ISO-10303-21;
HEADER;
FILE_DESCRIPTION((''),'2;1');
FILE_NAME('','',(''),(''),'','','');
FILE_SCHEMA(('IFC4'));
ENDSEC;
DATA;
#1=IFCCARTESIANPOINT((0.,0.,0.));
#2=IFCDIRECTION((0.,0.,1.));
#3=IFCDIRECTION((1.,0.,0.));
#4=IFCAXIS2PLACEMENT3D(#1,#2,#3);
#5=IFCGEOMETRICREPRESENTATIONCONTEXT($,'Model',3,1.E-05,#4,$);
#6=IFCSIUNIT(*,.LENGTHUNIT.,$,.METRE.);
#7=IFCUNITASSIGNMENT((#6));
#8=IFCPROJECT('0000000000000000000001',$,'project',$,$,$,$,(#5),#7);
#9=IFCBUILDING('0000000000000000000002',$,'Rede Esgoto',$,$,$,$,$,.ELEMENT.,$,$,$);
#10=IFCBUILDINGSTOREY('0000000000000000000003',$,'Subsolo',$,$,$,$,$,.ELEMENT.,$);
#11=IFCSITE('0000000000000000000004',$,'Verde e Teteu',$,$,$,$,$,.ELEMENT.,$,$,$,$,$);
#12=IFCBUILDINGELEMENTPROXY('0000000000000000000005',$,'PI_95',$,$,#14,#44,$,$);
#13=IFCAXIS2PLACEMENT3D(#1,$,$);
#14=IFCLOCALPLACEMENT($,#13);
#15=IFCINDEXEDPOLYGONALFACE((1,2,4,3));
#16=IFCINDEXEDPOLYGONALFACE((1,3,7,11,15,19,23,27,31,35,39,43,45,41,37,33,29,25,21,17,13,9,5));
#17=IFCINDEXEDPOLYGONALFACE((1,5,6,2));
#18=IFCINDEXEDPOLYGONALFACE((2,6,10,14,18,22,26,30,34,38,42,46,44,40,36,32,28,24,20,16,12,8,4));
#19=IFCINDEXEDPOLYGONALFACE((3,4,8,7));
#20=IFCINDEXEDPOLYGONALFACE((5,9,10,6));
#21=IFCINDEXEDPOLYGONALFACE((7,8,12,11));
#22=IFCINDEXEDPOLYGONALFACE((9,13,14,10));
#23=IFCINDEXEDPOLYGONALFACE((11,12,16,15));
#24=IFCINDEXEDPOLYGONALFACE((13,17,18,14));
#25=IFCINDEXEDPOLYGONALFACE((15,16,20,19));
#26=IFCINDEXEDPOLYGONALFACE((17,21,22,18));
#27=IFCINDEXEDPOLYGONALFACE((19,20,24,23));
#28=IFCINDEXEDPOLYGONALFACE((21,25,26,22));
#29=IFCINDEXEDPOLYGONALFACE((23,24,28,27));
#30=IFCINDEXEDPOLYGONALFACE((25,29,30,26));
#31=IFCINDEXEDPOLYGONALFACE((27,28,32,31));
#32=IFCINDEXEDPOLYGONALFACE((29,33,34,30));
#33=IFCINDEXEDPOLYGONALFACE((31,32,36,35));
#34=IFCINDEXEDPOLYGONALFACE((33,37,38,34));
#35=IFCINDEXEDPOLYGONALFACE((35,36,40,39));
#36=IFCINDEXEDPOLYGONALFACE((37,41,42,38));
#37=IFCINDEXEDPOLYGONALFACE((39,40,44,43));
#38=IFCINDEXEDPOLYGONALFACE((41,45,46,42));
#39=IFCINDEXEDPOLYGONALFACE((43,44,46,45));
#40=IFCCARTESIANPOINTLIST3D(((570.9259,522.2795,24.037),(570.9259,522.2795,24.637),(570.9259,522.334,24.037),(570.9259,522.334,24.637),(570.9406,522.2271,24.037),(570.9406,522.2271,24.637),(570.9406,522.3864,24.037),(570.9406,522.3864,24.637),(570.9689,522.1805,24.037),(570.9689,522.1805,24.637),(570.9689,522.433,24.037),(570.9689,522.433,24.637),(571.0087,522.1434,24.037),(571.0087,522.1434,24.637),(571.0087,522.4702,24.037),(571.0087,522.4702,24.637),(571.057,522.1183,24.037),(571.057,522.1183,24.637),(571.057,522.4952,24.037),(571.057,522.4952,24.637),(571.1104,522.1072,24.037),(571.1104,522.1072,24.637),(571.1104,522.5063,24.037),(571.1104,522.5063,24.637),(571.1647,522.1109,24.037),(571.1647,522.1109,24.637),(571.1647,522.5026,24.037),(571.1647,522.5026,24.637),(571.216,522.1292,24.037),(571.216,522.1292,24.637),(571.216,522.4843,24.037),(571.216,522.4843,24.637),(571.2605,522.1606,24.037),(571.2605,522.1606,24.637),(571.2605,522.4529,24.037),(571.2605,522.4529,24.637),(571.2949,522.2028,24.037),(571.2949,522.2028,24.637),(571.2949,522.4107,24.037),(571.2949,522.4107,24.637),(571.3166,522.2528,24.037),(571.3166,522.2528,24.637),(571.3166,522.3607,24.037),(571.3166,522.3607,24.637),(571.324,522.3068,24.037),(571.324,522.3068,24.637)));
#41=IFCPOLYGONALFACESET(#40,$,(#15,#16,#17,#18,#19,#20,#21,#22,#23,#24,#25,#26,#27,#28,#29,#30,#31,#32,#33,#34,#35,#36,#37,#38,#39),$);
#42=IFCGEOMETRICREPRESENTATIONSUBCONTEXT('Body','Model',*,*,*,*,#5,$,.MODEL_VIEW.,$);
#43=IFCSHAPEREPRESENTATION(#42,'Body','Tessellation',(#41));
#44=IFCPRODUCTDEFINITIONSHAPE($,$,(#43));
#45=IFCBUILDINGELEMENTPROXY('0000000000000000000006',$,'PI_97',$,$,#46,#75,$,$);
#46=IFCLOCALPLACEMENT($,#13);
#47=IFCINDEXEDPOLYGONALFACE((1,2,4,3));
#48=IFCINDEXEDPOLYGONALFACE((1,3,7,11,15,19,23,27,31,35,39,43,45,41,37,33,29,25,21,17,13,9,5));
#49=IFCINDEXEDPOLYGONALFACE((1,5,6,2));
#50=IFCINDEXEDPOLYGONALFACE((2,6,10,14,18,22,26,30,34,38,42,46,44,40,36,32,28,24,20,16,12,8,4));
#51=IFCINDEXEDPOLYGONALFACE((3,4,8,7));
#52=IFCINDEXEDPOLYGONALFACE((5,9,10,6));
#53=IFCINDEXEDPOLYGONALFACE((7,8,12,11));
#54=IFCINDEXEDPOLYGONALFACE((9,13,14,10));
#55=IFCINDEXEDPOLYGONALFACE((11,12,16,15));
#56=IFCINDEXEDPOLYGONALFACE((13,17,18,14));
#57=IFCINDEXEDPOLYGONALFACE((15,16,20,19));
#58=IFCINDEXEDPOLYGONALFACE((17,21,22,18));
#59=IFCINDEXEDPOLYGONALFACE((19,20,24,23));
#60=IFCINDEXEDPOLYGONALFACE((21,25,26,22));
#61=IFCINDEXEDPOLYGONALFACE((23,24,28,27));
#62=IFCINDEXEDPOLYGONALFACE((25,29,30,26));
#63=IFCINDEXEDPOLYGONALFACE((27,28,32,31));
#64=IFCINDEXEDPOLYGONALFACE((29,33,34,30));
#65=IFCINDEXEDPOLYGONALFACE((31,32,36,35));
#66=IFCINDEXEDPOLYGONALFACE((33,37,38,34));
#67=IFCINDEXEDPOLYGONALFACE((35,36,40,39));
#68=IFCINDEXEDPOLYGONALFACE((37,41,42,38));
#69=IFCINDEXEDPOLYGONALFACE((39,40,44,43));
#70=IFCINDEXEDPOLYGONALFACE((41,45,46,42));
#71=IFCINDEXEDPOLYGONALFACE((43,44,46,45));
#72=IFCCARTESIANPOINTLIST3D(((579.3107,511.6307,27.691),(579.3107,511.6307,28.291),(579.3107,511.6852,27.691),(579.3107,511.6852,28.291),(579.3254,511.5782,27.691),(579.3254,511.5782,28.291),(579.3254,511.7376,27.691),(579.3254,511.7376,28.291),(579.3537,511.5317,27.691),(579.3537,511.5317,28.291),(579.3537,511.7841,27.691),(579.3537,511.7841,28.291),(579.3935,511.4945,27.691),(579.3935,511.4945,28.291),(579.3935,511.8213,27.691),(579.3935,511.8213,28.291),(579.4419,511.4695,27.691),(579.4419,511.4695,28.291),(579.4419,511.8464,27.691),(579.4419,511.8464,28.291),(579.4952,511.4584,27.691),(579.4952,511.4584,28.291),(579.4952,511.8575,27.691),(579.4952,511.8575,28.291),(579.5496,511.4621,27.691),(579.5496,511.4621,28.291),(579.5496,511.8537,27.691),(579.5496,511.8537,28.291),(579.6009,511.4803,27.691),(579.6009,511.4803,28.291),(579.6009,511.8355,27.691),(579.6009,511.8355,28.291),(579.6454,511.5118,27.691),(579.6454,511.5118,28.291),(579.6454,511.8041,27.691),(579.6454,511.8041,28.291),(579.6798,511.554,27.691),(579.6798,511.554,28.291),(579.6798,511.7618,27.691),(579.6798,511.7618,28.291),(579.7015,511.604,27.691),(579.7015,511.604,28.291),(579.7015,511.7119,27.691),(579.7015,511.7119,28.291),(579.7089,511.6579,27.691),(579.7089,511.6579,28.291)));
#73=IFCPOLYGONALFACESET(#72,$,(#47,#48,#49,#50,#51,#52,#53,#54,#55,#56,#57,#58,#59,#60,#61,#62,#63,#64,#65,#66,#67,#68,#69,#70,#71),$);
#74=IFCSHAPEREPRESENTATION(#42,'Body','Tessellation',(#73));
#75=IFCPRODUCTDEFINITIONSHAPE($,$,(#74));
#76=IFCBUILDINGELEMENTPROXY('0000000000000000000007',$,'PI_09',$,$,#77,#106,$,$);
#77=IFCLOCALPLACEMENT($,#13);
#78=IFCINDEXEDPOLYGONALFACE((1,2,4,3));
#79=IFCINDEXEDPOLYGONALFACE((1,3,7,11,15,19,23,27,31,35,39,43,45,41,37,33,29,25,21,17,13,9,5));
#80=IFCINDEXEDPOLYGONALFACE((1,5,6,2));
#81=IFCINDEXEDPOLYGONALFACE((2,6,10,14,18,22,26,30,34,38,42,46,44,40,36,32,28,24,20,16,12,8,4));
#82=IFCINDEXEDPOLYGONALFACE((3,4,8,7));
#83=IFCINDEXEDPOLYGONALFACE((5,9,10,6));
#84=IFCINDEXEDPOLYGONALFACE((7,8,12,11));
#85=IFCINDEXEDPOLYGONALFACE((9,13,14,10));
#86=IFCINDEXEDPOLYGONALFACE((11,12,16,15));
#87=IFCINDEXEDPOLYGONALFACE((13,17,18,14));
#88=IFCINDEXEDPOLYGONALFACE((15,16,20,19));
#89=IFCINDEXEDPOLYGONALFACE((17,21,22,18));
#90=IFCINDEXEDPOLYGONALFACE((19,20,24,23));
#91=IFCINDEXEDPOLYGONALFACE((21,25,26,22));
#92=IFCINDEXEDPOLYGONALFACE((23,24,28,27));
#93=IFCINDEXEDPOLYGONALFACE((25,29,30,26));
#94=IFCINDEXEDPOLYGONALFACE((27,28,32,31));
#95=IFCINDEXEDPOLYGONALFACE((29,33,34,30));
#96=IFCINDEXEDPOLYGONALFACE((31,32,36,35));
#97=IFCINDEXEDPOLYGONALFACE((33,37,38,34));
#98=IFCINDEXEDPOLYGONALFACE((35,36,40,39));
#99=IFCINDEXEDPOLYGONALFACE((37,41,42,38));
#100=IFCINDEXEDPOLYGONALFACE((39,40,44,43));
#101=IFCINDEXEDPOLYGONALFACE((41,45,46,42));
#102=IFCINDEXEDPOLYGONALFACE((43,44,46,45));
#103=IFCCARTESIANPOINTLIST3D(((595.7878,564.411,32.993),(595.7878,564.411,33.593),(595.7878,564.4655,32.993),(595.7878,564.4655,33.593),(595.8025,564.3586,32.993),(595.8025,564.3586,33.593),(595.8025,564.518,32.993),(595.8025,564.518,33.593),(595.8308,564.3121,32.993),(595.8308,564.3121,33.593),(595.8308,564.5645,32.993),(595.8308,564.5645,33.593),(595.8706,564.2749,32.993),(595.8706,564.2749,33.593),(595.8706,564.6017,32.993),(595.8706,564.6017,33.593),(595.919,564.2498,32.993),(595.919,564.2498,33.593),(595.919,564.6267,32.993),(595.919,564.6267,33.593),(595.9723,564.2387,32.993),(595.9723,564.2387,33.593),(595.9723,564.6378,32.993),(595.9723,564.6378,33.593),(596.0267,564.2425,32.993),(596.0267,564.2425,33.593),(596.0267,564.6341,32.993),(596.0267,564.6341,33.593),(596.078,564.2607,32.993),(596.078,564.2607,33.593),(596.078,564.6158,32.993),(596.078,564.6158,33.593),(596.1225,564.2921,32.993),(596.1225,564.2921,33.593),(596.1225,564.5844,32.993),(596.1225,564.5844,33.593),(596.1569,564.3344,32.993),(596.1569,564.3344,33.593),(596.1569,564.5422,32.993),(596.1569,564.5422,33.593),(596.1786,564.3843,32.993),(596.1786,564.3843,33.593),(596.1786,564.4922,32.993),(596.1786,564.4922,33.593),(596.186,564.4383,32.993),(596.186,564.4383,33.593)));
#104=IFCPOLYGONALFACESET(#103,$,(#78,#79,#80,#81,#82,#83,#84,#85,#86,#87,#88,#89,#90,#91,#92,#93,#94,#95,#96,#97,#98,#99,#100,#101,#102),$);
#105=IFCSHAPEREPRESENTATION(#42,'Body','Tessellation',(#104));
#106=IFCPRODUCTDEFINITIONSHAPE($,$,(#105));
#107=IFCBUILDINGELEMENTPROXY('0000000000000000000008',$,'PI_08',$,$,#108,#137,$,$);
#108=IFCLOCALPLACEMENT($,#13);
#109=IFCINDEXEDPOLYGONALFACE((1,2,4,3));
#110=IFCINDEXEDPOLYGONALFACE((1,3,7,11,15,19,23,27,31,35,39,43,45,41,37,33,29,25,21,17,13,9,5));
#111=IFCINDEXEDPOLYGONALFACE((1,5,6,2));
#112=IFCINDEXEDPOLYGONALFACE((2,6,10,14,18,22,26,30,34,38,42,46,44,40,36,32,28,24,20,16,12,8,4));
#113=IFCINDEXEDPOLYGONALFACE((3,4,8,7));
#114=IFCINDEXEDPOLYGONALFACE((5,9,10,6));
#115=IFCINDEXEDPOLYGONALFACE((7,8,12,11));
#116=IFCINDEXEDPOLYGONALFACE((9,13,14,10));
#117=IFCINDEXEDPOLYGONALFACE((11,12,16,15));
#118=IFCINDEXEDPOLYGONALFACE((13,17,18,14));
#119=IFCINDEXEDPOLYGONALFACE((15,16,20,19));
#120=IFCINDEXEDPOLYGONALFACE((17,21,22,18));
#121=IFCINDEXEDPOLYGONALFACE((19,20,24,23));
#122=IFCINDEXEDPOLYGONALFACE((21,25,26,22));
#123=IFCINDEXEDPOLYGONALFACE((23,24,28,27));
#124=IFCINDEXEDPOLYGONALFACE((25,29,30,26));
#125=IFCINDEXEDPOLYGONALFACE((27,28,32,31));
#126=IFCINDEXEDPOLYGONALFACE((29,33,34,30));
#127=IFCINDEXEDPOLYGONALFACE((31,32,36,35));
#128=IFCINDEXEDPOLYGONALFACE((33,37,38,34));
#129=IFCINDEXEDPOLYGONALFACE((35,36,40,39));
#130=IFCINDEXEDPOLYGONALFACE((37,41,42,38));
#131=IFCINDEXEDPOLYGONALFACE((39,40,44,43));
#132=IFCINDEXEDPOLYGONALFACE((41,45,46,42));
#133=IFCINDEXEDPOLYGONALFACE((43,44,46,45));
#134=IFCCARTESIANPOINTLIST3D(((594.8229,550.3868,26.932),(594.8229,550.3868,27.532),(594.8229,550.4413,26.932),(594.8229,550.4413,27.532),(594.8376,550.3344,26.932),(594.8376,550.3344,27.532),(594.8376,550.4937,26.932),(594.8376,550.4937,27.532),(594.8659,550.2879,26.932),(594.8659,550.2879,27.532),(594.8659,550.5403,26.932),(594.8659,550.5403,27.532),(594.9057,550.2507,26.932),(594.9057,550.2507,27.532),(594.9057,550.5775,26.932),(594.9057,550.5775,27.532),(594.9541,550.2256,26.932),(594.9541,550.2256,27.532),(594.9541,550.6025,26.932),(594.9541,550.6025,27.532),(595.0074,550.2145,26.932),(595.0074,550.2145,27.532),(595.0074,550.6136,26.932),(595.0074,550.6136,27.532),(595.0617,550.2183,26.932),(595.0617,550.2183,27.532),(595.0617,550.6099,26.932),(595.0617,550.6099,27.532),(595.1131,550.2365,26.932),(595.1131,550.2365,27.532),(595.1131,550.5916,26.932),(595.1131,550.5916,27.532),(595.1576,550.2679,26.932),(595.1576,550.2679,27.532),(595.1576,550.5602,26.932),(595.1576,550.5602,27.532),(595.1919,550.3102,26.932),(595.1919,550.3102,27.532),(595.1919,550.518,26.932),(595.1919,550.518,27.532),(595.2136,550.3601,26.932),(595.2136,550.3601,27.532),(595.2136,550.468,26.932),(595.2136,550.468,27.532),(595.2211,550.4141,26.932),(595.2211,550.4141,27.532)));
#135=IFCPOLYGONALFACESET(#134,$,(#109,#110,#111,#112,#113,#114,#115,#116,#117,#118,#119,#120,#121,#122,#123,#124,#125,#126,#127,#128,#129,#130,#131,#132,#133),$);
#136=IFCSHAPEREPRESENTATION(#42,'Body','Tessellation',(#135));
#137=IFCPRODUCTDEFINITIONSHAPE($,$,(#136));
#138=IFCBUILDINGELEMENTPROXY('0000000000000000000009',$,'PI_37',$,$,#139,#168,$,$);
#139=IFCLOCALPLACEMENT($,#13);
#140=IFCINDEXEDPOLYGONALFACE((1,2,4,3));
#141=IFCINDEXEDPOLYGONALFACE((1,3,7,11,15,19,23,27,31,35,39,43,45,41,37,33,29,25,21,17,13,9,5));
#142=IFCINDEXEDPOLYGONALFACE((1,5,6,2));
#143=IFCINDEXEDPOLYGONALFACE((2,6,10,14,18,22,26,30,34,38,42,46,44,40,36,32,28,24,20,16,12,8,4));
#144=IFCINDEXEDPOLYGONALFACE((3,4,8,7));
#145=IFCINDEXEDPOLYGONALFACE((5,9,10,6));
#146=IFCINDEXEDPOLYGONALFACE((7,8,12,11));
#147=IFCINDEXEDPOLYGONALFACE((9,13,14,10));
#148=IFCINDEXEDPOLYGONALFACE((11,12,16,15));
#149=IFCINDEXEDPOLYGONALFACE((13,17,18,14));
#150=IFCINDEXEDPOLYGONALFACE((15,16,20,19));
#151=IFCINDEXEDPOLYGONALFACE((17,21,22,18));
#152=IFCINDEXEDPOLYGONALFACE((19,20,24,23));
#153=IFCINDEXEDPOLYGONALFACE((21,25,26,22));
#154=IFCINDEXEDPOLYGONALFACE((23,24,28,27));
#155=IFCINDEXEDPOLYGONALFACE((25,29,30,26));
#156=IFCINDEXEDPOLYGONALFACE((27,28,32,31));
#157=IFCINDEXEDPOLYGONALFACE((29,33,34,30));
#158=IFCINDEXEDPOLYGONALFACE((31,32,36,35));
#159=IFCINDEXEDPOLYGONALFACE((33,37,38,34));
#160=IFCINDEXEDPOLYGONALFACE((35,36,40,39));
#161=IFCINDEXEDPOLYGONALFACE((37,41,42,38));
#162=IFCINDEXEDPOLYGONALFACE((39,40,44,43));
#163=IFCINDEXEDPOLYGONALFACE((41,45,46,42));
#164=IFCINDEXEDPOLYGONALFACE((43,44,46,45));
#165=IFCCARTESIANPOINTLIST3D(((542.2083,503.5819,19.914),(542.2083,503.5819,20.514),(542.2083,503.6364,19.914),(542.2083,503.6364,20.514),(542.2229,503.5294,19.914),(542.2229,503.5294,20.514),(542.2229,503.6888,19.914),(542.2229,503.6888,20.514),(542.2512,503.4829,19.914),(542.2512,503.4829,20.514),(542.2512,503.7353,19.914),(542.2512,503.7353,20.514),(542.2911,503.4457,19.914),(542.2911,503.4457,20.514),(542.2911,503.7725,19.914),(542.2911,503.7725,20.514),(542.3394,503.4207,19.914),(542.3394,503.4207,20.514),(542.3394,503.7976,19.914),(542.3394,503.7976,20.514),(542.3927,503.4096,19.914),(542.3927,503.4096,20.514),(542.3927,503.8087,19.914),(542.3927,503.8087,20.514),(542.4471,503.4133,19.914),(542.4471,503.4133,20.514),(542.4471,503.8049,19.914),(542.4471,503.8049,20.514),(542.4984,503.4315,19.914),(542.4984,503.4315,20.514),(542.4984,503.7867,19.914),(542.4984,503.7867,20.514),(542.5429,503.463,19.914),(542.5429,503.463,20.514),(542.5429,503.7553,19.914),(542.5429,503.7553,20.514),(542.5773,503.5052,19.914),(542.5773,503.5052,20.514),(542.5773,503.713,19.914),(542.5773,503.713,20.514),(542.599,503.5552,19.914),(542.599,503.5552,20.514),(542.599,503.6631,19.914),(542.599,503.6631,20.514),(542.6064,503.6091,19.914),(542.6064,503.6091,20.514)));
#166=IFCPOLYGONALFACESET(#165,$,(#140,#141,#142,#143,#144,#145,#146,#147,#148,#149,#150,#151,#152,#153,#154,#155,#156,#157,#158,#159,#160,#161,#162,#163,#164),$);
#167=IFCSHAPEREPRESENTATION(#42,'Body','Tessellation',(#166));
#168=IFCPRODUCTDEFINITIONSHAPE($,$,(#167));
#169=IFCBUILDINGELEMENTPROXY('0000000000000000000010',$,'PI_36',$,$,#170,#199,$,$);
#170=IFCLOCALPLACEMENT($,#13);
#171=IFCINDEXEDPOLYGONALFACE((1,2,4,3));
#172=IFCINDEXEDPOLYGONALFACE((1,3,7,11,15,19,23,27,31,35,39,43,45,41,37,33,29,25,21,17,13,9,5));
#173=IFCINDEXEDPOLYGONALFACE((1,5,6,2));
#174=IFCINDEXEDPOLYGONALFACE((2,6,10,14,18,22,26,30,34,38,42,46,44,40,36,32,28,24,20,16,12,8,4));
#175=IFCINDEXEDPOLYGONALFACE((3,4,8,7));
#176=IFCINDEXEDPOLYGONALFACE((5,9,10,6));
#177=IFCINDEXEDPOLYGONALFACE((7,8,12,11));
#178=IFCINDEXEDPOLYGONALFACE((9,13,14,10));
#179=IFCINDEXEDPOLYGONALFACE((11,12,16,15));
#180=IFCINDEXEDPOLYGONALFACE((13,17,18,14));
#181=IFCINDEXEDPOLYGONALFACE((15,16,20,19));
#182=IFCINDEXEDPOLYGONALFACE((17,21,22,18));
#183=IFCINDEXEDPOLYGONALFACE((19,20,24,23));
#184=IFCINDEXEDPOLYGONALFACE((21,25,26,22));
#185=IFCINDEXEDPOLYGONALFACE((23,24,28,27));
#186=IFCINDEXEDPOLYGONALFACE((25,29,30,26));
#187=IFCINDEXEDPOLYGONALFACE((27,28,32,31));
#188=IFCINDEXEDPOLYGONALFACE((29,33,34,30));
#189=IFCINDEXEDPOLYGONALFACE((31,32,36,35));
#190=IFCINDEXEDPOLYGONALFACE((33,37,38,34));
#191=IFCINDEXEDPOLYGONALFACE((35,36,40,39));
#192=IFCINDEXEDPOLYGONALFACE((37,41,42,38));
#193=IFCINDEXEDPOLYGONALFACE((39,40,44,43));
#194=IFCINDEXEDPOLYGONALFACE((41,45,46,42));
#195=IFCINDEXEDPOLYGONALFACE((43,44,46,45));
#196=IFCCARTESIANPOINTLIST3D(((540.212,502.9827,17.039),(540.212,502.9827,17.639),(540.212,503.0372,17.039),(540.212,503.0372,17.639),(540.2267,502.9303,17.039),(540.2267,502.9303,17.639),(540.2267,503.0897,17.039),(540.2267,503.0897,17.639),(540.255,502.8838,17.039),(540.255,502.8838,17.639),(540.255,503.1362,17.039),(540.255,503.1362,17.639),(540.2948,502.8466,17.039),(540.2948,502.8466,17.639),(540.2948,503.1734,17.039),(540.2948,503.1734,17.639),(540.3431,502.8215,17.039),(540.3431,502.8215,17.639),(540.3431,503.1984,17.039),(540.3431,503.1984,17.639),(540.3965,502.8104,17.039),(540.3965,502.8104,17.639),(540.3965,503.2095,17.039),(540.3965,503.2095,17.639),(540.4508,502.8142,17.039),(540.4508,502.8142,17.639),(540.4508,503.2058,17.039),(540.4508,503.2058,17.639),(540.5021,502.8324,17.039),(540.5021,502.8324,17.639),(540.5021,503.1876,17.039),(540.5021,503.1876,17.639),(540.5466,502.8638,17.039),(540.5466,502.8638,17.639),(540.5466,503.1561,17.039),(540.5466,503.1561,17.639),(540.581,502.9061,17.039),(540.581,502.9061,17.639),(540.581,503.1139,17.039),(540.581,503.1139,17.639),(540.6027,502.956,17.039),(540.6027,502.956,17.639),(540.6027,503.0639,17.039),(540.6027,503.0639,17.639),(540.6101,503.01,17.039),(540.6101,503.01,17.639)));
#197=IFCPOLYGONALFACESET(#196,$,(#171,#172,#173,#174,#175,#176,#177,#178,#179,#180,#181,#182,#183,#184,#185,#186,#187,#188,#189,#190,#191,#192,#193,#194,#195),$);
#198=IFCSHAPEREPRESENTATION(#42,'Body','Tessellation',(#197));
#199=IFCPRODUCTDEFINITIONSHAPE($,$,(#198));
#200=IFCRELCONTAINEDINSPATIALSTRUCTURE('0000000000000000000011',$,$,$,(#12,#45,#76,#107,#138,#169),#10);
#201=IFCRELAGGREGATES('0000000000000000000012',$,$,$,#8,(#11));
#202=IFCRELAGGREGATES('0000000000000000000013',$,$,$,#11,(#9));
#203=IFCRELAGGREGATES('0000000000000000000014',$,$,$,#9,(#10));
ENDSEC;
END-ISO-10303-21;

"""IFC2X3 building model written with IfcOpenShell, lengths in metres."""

from ifc_helpers import new_model, si_unit, frame, origin_with_axes, origin_2d, place, context, subcontext, project, spatial, circle, extrude, element, save


model = new_model("IFC2X3")

# Units and contexts
model_context = context("Model", 3, precision=1e-05, world=origin_with_axes())
body_context = subcontext(model_context, "Body", "Model", "MODEL_VIEW")
ifc_project = project(units=[si_unit("LENGTHUNIT", "METRE")], contexts=[model_context])

# Site, building, storey
site = spatial("IfcSite", under=ifc_project, Name="Verde e Teteu", CompositionType="ELEMENT")
building = spatial("IfcBuilding", under=site, Name="Rede Esgoto", CompositionType="ELEMENT")
storey = spatial("IfcBuildingStorey", under=building, Name="Subsolo", CompositionType="ELEMENT")

# Building element proxies
for number, where, z_axis, x_axis, name in (
    (1, (571.124, 522.3068, 24.037), (0.0, 0.0, 1.0), (1.0, 0.0, 0.0), "PI_95"),
    (2, (579.5089, 511.6579, 27.691), (0.0, 0.0, 1.0), (1.0, 0.0, 0.0), "PI_97"),
    (3, (595.986, 564.4383, 32.993), (0.0, 0.0, 1.0), (1.0, 0.0, 0.0), "PI_09"),
    (4, (595.0211, 550.4141, 26.932), (0.0, 0.0, 1.0), (1.0, 0.0, 0.0), "PI_08"),
):
    element("IfcBuildingElementProxy", number, at=place(None, frame(where, z_axis=z_axis, x_axis=x_axis)), inside=storey, Name=name, context=body_context, shape_type="SweptSolid", body=[
        extrude(circle(Radius=0.2, at=origin_2d()), origin_with_axes(), (0.0, 0.0, 1.0), 0.6),
    ])
for number, where, z_axis, x_axis, name in (
    (5, (542.4064, 503.6091, 19.914), (0.0, 0.0, 1.0), (1.0, 0.0, 0.0), "PI_37"),
    (6, (540.4101, 503.01, 17.039), (0.0, 0.0, 1.0), (1.0, 0.0, 0.0), "PI_36"),
):
    element("IfcBuildingElementProxy", number, at=place(None, frame(where, z_axis=z_axis, x_axis=x_axis)), inside=storey, Name=name, context=body_context, shape_type="SweptSolid", body=[
        extrude(circle(Radius=0.2, at=origin_2d()), origin_with_axes(), (0.0, 0.0, 1.0), 0.6),
    ])

save(model, "model.ifc")
